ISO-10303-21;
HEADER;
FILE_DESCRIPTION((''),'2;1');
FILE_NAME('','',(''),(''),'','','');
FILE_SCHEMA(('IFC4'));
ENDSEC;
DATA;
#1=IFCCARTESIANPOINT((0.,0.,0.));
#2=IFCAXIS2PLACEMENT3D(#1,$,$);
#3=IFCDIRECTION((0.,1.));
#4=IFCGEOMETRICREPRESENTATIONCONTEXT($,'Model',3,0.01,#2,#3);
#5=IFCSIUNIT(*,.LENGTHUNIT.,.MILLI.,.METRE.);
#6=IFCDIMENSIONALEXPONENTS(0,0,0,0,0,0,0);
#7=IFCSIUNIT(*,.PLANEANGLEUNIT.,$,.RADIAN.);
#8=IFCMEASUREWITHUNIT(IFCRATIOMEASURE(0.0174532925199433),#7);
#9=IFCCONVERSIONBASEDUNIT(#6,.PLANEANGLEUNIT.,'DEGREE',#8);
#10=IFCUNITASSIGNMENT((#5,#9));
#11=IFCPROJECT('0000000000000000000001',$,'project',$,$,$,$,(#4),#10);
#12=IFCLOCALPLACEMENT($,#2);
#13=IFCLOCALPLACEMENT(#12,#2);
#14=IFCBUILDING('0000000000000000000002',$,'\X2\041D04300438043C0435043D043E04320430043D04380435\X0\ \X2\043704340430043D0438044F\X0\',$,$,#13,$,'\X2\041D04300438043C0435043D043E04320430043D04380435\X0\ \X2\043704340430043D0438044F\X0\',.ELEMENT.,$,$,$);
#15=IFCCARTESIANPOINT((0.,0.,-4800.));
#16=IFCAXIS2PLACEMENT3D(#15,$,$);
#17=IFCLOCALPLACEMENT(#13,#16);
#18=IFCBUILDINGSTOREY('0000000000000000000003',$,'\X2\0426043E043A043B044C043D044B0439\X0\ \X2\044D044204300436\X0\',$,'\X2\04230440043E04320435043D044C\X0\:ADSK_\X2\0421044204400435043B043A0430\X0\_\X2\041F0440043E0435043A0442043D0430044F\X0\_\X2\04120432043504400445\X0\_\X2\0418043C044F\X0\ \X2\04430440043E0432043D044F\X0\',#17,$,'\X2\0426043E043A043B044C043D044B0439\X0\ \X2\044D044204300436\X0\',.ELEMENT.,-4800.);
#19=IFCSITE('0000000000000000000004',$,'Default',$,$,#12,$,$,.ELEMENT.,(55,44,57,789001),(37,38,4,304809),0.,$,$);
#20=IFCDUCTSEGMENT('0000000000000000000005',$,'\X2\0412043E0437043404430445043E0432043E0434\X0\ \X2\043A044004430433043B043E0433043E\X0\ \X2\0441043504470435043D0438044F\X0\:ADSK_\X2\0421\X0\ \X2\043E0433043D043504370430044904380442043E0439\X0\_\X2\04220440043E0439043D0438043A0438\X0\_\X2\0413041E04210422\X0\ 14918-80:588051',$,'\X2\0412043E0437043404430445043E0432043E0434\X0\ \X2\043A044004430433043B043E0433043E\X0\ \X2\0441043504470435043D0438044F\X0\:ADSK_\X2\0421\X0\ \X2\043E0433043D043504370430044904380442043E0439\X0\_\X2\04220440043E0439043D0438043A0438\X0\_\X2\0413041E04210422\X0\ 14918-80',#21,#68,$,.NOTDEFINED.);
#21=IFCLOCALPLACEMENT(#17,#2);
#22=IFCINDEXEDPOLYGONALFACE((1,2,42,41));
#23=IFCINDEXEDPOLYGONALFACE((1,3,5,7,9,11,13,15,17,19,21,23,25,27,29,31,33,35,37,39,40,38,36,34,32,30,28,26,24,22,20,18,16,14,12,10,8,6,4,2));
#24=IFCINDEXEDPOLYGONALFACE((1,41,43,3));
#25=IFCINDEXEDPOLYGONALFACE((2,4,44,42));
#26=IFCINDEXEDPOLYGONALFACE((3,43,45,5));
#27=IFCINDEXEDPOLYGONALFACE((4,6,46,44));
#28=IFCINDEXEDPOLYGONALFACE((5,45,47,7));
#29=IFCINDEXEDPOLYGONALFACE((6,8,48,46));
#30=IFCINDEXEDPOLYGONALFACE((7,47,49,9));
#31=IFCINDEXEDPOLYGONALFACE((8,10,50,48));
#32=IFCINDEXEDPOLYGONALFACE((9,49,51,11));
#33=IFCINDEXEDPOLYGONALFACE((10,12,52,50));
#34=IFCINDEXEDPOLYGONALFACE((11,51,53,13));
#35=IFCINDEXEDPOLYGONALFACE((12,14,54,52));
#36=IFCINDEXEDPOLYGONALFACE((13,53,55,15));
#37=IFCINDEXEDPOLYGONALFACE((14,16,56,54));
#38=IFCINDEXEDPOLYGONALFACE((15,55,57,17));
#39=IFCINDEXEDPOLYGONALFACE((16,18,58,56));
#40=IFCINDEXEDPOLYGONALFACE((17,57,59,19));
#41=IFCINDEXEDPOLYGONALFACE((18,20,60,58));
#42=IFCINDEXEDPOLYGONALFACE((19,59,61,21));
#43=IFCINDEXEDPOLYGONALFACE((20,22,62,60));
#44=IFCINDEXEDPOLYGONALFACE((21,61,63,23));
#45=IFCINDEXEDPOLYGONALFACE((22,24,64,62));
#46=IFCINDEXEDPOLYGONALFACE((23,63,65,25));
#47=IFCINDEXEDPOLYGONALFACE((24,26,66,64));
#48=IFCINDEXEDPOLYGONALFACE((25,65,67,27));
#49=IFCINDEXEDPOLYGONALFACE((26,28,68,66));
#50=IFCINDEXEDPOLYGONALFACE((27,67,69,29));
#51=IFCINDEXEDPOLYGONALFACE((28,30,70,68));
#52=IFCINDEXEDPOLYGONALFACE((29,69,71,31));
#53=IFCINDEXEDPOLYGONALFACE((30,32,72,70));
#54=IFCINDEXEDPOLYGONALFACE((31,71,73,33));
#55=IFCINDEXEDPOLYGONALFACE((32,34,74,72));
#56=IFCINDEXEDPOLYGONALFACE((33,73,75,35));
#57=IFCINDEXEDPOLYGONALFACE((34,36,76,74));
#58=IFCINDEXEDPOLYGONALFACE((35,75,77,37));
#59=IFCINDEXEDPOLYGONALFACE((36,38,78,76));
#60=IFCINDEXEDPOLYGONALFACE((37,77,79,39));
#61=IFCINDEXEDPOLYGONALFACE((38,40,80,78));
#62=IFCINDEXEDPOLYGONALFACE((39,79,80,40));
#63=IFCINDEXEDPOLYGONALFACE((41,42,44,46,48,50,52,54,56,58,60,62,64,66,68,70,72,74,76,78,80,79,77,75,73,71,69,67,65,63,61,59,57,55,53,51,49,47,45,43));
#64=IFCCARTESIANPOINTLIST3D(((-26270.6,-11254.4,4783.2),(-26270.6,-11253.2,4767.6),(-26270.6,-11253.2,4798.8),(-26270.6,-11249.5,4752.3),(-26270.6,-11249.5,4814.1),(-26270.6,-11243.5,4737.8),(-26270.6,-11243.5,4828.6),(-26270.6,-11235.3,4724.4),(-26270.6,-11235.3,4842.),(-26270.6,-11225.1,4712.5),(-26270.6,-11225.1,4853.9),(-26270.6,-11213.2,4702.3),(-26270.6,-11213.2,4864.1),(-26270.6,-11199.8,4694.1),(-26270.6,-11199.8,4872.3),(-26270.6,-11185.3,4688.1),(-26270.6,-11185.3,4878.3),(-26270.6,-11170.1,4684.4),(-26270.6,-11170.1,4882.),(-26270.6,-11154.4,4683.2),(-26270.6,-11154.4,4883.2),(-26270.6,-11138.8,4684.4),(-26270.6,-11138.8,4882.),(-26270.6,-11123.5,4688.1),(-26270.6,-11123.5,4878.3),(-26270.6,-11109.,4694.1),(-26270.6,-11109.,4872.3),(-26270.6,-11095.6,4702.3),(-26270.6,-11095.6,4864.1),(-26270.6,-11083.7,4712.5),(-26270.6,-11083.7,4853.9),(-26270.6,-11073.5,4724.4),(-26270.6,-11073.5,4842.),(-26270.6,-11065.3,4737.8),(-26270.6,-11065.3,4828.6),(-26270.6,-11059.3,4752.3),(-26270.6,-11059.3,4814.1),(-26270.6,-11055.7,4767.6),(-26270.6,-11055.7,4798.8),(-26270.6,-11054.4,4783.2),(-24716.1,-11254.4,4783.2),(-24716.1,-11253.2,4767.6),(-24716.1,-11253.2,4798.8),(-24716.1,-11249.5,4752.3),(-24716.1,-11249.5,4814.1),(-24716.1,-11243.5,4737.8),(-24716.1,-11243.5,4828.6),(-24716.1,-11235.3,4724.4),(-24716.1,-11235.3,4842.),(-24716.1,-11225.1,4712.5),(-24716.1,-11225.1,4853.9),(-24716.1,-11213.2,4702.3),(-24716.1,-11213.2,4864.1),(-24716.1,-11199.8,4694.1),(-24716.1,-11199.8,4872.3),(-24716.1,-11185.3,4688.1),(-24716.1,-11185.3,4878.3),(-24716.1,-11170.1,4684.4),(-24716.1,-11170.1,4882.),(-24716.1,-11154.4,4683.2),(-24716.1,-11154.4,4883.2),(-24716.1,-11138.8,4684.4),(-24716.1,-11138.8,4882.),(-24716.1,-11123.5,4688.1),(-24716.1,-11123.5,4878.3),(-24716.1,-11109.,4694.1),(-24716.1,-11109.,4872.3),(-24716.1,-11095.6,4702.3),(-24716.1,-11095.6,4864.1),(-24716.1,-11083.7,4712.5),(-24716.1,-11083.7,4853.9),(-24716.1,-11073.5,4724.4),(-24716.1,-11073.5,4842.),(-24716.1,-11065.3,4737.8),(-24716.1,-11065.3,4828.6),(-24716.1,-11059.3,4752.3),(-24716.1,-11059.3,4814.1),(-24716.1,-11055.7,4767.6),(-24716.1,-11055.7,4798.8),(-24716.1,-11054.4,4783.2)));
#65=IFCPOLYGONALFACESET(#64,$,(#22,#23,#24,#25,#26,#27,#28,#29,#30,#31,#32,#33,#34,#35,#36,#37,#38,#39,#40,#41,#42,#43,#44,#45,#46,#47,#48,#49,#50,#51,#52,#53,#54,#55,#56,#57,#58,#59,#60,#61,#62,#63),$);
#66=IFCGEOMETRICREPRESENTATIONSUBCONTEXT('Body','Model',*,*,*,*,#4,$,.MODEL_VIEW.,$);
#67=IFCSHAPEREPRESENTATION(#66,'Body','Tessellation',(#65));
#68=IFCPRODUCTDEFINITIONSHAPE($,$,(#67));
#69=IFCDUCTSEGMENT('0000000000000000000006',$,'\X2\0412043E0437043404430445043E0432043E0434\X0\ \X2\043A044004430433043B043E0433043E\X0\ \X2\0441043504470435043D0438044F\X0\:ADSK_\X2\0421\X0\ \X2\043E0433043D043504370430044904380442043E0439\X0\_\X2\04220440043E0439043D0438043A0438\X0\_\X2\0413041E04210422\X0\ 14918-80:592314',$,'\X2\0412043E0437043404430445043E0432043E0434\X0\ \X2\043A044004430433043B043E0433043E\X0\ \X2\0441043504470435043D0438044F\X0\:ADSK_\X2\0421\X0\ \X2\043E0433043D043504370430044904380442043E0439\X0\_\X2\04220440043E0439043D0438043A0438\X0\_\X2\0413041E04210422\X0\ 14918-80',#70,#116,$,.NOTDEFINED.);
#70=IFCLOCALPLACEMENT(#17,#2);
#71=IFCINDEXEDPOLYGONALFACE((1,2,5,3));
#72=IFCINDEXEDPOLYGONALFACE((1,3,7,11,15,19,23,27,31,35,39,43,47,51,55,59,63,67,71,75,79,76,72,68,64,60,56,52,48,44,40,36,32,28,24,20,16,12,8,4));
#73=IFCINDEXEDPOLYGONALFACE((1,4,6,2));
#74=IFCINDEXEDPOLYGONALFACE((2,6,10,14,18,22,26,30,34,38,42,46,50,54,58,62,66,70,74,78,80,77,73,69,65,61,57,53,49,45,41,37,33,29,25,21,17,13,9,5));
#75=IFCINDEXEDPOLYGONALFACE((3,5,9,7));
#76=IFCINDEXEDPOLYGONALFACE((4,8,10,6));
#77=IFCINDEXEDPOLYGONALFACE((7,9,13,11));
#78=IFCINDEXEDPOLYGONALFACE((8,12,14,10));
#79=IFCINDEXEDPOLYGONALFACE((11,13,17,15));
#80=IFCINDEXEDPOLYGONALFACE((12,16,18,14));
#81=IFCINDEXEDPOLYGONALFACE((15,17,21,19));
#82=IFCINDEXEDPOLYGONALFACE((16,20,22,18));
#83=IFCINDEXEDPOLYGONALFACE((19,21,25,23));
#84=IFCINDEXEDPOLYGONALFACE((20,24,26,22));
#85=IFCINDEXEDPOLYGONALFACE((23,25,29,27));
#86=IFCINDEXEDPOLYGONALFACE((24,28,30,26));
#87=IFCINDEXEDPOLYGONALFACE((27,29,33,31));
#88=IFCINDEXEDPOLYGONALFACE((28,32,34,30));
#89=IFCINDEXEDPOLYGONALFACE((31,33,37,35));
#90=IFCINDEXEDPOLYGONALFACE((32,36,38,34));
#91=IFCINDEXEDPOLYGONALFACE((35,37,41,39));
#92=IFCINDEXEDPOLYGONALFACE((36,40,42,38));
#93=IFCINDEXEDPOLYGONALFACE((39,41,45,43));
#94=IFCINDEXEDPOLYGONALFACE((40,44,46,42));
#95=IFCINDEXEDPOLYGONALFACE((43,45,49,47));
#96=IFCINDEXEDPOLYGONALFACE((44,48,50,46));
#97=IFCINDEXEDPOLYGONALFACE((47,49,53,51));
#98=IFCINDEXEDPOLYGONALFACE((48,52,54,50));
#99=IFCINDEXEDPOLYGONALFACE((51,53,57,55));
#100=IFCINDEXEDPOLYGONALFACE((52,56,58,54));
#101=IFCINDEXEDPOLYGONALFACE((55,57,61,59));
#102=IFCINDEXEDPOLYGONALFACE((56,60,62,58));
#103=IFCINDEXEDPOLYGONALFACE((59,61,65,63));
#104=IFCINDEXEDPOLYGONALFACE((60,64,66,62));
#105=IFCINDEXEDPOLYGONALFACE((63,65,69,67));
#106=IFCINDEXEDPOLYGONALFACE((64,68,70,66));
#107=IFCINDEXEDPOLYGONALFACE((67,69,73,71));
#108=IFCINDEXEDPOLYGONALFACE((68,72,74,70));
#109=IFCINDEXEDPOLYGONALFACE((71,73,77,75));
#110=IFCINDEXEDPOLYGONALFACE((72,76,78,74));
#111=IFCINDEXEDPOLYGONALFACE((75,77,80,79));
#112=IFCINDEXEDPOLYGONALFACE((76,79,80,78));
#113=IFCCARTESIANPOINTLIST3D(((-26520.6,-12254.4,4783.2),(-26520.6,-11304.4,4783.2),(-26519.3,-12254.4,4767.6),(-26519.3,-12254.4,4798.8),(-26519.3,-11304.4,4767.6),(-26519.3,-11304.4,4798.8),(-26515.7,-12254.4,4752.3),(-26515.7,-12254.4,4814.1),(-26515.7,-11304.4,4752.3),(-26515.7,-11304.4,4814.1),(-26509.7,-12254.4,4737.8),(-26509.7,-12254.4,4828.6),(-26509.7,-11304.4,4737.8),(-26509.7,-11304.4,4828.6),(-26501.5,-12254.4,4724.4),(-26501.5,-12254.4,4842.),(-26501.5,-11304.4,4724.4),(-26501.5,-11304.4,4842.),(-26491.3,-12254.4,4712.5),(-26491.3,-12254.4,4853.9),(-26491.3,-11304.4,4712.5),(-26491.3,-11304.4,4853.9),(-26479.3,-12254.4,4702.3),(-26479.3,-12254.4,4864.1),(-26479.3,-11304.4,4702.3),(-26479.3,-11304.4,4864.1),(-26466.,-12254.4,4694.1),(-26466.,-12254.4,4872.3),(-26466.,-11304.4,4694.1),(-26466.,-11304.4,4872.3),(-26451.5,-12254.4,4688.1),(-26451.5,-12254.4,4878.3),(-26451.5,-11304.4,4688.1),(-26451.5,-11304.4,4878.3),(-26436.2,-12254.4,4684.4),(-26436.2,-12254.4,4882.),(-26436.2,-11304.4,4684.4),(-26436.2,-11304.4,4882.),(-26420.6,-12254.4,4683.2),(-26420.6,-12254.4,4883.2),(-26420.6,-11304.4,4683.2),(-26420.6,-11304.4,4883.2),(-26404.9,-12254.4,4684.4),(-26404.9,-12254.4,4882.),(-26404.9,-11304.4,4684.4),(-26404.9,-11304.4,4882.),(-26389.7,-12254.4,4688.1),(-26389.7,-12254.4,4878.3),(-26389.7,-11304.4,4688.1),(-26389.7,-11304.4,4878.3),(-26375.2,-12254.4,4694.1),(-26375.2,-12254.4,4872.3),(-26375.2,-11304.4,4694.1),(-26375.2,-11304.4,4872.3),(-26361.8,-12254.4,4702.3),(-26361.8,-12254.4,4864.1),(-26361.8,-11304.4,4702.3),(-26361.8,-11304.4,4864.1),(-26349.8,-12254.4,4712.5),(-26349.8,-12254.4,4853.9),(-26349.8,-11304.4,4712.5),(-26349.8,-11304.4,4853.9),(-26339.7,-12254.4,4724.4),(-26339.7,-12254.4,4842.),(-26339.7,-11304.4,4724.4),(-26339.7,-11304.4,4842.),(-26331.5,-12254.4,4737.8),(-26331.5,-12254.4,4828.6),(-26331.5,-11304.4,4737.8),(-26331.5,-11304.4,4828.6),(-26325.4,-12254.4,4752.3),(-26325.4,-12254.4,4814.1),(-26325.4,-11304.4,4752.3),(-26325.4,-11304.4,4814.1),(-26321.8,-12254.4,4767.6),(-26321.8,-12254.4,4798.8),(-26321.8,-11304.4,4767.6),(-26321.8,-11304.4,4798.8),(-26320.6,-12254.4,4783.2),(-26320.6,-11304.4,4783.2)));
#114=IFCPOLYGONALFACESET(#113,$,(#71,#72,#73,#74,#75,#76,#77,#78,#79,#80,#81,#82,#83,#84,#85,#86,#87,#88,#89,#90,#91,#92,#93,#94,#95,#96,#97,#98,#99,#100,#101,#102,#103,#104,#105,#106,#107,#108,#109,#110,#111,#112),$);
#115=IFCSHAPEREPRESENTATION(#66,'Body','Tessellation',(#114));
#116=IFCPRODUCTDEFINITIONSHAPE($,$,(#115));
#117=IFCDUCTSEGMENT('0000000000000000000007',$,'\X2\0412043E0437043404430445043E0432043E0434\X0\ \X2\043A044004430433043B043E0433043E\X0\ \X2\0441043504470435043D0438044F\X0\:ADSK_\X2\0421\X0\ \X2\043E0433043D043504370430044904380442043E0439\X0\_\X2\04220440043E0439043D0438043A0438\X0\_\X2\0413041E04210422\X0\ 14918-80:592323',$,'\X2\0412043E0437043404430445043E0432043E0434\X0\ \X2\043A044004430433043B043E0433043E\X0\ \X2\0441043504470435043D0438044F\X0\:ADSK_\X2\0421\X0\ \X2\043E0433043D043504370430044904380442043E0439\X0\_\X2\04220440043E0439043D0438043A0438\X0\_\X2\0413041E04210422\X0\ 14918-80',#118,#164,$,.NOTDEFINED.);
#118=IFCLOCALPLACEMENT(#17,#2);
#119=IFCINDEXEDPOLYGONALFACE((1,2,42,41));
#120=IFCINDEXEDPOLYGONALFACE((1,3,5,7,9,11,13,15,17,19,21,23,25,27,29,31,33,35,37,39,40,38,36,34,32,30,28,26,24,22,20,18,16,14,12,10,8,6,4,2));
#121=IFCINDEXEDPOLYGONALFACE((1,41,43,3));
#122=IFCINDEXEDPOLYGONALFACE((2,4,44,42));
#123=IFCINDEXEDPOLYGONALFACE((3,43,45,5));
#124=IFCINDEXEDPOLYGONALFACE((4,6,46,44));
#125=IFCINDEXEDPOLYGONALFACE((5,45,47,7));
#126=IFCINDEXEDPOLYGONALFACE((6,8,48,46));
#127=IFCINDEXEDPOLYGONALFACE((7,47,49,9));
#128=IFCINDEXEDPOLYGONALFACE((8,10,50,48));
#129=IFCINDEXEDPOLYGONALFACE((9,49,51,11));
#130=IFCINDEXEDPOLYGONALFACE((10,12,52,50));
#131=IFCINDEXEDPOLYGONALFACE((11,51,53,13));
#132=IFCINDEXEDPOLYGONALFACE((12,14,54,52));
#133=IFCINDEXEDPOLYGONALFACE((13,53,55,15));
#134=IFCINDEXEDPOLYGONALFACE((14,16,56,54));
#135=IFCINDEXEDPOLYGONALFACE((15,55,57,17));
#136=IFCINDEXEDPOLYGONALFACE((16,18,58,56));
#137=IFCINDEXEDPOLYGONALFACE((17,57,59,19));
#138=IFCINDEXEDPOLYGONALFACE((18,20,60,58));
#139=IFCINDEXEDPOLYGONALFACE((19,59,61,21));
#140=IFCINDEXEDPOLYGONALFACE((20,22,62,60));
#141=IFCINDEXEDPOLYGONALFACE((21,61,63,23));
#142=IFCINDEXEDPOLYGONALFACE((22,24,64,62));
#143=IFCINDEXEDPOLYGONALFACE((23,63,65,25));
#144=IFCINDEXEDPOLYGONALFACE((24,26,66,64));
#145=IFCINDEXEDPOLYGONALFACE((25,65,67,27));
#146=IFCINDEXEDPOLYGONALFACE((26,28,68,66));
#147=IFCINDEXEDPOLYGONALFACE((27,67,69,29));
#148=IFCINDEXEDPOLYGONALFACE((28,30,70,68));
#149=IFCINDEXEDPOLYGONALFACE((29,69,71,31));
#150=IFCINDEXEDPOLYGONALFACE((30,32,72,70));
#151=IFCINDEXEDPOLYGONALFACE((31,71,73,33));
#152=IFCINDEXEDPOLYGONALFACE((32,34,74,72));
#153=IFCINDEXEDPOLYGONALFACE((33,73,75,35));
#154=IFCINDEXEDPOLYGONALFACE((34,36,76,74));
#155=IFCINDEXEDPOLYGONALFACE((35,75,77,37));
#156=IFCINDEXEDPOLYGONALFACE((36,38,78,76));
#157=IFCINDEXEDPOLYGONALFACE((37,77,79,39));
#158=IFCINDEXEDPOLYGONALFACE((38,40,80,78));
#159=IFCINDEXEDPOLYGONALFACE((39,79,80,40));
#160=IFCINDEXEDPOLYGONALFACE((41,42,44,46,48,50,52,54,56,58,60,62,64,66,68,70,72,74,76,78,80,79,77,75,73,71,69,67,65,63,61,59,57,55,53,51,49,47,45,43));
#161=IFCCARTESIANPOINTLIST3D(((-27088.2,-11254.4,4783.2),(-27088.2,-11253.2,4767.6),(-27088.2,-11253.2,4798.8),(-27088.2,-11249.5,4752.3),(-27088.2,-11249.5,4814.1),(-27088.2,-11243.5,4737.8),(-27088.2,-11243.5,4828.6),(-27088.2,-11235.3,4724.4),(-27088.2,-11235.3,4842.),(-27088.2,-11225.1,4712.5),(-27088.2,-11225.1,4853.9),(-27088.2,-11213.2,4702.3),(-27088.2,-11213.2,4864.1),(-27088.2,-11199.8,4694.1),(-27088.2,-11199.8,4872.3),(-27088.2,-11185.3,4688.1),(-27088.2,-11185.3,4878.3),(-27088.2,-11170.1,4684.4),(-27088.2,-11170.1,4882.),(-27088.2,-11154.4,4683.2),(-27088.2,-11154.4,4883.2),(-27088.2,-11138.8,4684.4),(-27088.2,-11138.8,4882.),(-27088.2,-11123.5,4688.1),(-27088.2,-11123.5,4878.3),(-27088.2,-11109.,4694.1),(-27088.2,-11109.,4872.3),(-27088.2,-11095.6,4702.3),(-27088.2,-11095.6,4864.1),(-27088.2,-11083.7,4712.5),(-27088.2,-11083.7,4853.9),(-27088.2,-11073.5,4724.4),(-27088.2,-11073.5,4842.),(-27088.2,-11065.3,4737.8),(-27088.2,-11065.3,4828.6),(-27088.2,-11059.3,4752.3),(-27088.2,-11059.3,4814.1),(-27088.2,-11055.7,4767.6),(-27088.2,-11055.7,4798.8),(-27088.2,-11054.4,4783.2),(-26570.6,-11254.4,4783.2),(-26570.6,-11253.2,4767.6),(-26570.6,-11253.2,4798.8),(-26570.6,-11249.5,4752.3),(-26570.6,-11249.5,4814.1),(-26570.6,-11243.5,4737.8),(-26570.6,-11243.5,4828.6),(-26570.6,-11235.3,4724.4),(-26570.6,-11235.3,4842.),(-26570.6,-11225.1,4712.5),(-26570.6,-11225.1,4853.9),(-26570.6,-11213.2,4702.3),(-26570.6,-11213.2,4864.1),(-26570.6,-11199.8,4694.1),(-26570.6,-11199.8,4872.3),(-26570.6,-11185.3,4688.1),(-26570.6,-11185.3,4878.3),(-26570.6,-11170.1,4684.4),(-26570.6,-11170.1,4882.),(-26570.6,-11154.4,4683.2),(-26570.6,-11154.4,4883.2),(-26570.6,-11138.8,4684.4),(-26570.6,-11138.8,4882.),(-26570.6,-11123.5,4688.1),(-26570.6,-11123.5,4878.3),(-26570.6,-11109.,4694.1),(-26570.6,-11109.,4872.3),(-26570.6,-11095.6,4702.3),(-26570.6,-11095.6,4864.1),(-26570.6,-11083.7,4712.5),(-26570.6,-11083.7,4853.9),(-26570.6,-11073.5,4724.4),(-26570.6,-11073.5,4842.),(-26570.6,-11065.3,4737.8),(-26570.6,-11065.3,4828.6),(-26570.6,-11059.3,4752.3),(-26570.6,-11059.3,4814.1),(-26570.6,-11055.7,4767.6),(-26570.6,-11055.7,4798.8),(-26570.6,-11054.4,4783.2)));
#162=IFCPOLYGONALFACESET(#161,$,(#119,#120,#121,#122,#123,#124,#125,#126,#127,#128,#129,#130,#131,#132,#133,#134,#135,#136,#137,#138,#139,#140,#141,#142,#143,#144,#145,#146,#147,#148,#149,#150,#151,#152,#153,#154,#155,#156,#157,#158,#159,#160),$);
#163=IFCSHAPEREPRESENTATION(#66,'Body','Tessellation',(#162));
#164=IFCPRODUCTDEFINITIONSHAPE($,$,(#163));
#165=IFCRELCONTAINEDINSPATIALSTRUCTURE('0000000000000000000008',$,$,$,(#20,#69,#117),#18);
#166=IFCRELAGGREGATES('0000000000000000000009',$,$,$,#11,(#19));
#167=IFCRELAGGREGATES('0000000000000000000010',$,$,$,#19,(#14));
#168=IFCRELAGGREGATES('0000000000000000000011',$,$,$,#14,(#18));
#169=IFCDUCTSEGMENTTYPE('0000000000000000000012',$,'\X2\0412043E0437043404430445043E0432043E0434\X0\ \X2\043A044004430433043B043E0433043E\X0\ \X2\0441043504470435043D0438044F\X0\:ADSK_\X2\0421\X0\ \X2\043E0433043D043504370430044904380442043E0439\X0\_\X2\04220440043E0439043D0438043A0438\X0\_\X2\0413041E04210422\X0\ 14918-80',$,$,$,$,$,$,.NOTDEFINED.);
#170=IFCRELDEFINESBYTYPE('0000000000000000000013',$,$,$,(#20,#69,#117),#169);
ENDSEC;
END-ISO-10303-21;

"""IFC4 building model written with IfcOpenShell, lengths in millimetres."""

from ifc_helpers import new_model, entity, si_unit, converted_unit, direction, frame, origin, place, context, subcontext, project, spatial, indexed_curve, outline, extrude, type_object, element, save


model = new_model("IFC4")

# Units and contexts
model_context = context("Model", 3, precision=0.01, world=origin(), true_north=direction((0.0, 1.0)))
body_context = subcontext(model_context, "Body", "Model", "MODEL_VIEW")
ifc_project = project(units=[si_unit("LENGTHUNIT", "METRE", prefix="MILLI"), converted_unit("PLANEANGLEUNIT", "DEGREE", entity("IfcRatioMeasure", 0.0174532925199433), si_unit("PLANEANGLEUNIT", "RADIAN"), dimensions=[0, 0, 0, 0, 0, 0, 0])], contexts=[model_context])

# Site, building, storey
site_placement = place(None, origin())
site = spatial("IfcSite", under=ifc_project, at=site_placement, Name="Default", CompositionType="ELEMENT", RefLatitude=(55, 44, 57, 789001), RefLongitude=(37, 38, 4, 304809), RefElevation=0.0)
building_placement = place(site_placement, origin())
building = spatial("IfcBuilding", under=site, at=building_placement, Name="Наименование здания", LongName="Наименование здания", CompositionType="ELEMENT")
storey_placement = place(building_placement, frame((0.0, 0.0, -4800.0)))
storey = spatial("IfcBuildingStorey", under=building, at=storey_placement, Name="Цокльный этаж", ObjectType="Уровень:ADSK_Стрелка_Проектная_Вверх_Имя уровня", LongName="Цокльный этаж", CompositionType="ELEMENT", Elevation=-4800.0)

# Duct segments
duct_segment_type = type_object("IfcDuctSegmentType", Name="Воздуховод круглого сечения:ADSK_С огнезащитой_Тройники_ГОСТ 14918-80", PredefinedType="NOTDEFINED")
duct_segment_1_placement = place(storey_placement, origin())
element("IfcDuctSegment", 1, at=duct_segment_1_placement, inside=storey, type_object=duct_segment_type, Name="Воздуховод круглого сечения:ADSK_С огнезащитой_Тройники_ГОСТ 14918-80:588051", ObjectType="Воздуховод круглого сечения:ADSK_С огнезащитой_Тройники_ГОСТ 14918-80", PredefinedType="NOTDEFINED", context=body_context, shape_type="SweptSolid", body=[
    extrude(outline(indexed_curve([(100.0, 0.0), (98.8, 15.6), (95.1, 30.9), (89.1, 45.4), (80.9, 58.8), (70.7, 70.7), (58.8, 80.9), (45.4, 89.1), (30.9, 95.1), (15.6, 98.8), (0.0, 100.0), (-15.6, 98.8), (-30.9, 95.1), (-45.4, 89.1), (-58.8, 80.9), (-70.7, 70.7), (-80.9, 58.8), (-89.1, 45.4), (-95.1, 30.9), (-98.8, 15.6), (-100.0, 0.0), (-98.8, -15.6), (-95.1, -30.9), (-89.1, -45.4), (-80.9, -58.8), (-70.7, -70.7), (-58.8, -80.9), (-45.4, -89.1), (-30.9, -95.1), (-15.6, -98.8), (0.0, -100.0), (15.6, -98.8), (30.9, -95.1), (45.4, -89.1), (58.8, -80.9), (70.7, -70.7), (80.9, -58.8), (89.1, -45.4), (95.1, -30.9), (98.8, -15.6), (100.0, 0.0)], self_intersect=False)), frame((-26270.6, -11154.4, 4783.2), z_axis=(1.0, 0.0, 0.0), x_axis=(0.0, -1.0, 0.0)), (0.0, 0.0, 1.0), 1554.5),
])
duct_segment_2_placement = place(storey_placement, origin())
element("IfcDuctSegment", 2, at=duct_segment_2_placement, inside=storey, type_object=duct_segment_type, Name="Воздуховод круглого сечения:ADSK_С огнезащитой_Тройники_ГОСТ 14918-80:592314", ObjectType="Воздуховод круглого сечения:ADSK_С огнезащитой_Тройники_ГОСТ 14918-80", PredefinedType="NOTDEFINED", context=body_context, shape_type="SweptSolid", body=[
    extrude(outline(indexed_curve([(100.0, 0.0), (98.8, 15.6), (95.1, 30.9), (89.1, 45.4), (80.9, 58.8), (70.7, 70.7), (58.8, 80.9), (45.4, 89.1), (30.9, 95.1), (15.6, 98.8), (0.0, 100.0), (-15.6, 98.8), (-30.9, 95.1), (-45.4, 89.1), (-58.8, 80.9), (-70.7, 70.7), (-80.9, 58.8), (-89.1, 45.4), (-95.1, 30.9), (-98.8, 15.6), (-100.0, 0.0), (-98.8, -15.6), (-95.1, -30.9), (-89.1, -45.4), (-80.9, -58.8), (-70.7, -70.7), (-58.8, -80.9), (-45.4, -89.1), (-30.9, -95.1), (-15.6, -98.8), (0.0, -100.0), (15.6, -98.8), (30.9, -95.1), (45.4, -89.1), (58.8, -80.9), (70.7, -70.7), (80.9, -58.8), (89.1, -45.4), (95.1, -30.9), (98.8, -15.6), (100.0, 0.0)], self_intersect=False)), frame((-26420.6, -12254.4, 4783.2), z_axis=(0.0, 1.0, 0.0), x_axis=(-1.0, 0.0, 0.0)), (0.0, 0.0, 1.0), 950.0),
])
duct_segment_3_placement = place(storey_placement, origin())
element("IfcDuctSegment", 3, at=duct_segment_3_placement, inside=storey, type_object=duct_segment_type, Name="Воздуховод круглого сечения:ADSK_С огнезащитой_Тройники_ГОСТ 14918-80:592323", ObjectType="Воздуховод круглого сечения:ADSK_С огнезащитой_Тройники_ГОСТ 14918-80", PredefinedType="NOTDEFINED", context=body_context, shape_type="SweptSolid", body=[
    extrude(outline(indexed_curve([(100.0, 0.0), (98.8, 15.6), (95.1, 30.9), (89.1, 45.4), (80.9, 58.8), (70.7, 70.7), (58.8, 80.9), (45.4, 89.1), (30.9, 95.1), (15.6, 98.8), (0.0, 100.0), (-15.6, 98.8), (-30.9, 95.1), (-45.4, 89.1), (-58.8, 80.9), (-70.7, 70.7), (-80.9, 58.8), (-89.1, 45.4), (-95.1, 30.9), (-98.8, 15.6), (-100.0, 0.0), (-98.8, -15.6), (-95.1, -30.9), (-89.1, -45.4), (-80.9, -58.8), (-70.7, -70.7), (-58.8, -80.9), (-45.4, -89.1), (-30.9, -95.1), (-15.6, -98.8), (0.0, -100.0), (15.6, -98.8), (30.9, -95.1), (45.4, -89.1), (58.8, -80.9), (70.7, -70.7), (80.9, -58.8), (89.1, -45.4), (95.1, -30.9), (98.8, -15.6), (100.0, 0.0)], self_intersect=False)), frame((-27088.2, -11154.4, 4783.2), z_axis=(1.0, 0.0, 0.0), x_axis=(0.0, -1.0, 0.0)), (0.0, 0.0, 1.0), 517.7),
])

save(model, "model.ifc")
